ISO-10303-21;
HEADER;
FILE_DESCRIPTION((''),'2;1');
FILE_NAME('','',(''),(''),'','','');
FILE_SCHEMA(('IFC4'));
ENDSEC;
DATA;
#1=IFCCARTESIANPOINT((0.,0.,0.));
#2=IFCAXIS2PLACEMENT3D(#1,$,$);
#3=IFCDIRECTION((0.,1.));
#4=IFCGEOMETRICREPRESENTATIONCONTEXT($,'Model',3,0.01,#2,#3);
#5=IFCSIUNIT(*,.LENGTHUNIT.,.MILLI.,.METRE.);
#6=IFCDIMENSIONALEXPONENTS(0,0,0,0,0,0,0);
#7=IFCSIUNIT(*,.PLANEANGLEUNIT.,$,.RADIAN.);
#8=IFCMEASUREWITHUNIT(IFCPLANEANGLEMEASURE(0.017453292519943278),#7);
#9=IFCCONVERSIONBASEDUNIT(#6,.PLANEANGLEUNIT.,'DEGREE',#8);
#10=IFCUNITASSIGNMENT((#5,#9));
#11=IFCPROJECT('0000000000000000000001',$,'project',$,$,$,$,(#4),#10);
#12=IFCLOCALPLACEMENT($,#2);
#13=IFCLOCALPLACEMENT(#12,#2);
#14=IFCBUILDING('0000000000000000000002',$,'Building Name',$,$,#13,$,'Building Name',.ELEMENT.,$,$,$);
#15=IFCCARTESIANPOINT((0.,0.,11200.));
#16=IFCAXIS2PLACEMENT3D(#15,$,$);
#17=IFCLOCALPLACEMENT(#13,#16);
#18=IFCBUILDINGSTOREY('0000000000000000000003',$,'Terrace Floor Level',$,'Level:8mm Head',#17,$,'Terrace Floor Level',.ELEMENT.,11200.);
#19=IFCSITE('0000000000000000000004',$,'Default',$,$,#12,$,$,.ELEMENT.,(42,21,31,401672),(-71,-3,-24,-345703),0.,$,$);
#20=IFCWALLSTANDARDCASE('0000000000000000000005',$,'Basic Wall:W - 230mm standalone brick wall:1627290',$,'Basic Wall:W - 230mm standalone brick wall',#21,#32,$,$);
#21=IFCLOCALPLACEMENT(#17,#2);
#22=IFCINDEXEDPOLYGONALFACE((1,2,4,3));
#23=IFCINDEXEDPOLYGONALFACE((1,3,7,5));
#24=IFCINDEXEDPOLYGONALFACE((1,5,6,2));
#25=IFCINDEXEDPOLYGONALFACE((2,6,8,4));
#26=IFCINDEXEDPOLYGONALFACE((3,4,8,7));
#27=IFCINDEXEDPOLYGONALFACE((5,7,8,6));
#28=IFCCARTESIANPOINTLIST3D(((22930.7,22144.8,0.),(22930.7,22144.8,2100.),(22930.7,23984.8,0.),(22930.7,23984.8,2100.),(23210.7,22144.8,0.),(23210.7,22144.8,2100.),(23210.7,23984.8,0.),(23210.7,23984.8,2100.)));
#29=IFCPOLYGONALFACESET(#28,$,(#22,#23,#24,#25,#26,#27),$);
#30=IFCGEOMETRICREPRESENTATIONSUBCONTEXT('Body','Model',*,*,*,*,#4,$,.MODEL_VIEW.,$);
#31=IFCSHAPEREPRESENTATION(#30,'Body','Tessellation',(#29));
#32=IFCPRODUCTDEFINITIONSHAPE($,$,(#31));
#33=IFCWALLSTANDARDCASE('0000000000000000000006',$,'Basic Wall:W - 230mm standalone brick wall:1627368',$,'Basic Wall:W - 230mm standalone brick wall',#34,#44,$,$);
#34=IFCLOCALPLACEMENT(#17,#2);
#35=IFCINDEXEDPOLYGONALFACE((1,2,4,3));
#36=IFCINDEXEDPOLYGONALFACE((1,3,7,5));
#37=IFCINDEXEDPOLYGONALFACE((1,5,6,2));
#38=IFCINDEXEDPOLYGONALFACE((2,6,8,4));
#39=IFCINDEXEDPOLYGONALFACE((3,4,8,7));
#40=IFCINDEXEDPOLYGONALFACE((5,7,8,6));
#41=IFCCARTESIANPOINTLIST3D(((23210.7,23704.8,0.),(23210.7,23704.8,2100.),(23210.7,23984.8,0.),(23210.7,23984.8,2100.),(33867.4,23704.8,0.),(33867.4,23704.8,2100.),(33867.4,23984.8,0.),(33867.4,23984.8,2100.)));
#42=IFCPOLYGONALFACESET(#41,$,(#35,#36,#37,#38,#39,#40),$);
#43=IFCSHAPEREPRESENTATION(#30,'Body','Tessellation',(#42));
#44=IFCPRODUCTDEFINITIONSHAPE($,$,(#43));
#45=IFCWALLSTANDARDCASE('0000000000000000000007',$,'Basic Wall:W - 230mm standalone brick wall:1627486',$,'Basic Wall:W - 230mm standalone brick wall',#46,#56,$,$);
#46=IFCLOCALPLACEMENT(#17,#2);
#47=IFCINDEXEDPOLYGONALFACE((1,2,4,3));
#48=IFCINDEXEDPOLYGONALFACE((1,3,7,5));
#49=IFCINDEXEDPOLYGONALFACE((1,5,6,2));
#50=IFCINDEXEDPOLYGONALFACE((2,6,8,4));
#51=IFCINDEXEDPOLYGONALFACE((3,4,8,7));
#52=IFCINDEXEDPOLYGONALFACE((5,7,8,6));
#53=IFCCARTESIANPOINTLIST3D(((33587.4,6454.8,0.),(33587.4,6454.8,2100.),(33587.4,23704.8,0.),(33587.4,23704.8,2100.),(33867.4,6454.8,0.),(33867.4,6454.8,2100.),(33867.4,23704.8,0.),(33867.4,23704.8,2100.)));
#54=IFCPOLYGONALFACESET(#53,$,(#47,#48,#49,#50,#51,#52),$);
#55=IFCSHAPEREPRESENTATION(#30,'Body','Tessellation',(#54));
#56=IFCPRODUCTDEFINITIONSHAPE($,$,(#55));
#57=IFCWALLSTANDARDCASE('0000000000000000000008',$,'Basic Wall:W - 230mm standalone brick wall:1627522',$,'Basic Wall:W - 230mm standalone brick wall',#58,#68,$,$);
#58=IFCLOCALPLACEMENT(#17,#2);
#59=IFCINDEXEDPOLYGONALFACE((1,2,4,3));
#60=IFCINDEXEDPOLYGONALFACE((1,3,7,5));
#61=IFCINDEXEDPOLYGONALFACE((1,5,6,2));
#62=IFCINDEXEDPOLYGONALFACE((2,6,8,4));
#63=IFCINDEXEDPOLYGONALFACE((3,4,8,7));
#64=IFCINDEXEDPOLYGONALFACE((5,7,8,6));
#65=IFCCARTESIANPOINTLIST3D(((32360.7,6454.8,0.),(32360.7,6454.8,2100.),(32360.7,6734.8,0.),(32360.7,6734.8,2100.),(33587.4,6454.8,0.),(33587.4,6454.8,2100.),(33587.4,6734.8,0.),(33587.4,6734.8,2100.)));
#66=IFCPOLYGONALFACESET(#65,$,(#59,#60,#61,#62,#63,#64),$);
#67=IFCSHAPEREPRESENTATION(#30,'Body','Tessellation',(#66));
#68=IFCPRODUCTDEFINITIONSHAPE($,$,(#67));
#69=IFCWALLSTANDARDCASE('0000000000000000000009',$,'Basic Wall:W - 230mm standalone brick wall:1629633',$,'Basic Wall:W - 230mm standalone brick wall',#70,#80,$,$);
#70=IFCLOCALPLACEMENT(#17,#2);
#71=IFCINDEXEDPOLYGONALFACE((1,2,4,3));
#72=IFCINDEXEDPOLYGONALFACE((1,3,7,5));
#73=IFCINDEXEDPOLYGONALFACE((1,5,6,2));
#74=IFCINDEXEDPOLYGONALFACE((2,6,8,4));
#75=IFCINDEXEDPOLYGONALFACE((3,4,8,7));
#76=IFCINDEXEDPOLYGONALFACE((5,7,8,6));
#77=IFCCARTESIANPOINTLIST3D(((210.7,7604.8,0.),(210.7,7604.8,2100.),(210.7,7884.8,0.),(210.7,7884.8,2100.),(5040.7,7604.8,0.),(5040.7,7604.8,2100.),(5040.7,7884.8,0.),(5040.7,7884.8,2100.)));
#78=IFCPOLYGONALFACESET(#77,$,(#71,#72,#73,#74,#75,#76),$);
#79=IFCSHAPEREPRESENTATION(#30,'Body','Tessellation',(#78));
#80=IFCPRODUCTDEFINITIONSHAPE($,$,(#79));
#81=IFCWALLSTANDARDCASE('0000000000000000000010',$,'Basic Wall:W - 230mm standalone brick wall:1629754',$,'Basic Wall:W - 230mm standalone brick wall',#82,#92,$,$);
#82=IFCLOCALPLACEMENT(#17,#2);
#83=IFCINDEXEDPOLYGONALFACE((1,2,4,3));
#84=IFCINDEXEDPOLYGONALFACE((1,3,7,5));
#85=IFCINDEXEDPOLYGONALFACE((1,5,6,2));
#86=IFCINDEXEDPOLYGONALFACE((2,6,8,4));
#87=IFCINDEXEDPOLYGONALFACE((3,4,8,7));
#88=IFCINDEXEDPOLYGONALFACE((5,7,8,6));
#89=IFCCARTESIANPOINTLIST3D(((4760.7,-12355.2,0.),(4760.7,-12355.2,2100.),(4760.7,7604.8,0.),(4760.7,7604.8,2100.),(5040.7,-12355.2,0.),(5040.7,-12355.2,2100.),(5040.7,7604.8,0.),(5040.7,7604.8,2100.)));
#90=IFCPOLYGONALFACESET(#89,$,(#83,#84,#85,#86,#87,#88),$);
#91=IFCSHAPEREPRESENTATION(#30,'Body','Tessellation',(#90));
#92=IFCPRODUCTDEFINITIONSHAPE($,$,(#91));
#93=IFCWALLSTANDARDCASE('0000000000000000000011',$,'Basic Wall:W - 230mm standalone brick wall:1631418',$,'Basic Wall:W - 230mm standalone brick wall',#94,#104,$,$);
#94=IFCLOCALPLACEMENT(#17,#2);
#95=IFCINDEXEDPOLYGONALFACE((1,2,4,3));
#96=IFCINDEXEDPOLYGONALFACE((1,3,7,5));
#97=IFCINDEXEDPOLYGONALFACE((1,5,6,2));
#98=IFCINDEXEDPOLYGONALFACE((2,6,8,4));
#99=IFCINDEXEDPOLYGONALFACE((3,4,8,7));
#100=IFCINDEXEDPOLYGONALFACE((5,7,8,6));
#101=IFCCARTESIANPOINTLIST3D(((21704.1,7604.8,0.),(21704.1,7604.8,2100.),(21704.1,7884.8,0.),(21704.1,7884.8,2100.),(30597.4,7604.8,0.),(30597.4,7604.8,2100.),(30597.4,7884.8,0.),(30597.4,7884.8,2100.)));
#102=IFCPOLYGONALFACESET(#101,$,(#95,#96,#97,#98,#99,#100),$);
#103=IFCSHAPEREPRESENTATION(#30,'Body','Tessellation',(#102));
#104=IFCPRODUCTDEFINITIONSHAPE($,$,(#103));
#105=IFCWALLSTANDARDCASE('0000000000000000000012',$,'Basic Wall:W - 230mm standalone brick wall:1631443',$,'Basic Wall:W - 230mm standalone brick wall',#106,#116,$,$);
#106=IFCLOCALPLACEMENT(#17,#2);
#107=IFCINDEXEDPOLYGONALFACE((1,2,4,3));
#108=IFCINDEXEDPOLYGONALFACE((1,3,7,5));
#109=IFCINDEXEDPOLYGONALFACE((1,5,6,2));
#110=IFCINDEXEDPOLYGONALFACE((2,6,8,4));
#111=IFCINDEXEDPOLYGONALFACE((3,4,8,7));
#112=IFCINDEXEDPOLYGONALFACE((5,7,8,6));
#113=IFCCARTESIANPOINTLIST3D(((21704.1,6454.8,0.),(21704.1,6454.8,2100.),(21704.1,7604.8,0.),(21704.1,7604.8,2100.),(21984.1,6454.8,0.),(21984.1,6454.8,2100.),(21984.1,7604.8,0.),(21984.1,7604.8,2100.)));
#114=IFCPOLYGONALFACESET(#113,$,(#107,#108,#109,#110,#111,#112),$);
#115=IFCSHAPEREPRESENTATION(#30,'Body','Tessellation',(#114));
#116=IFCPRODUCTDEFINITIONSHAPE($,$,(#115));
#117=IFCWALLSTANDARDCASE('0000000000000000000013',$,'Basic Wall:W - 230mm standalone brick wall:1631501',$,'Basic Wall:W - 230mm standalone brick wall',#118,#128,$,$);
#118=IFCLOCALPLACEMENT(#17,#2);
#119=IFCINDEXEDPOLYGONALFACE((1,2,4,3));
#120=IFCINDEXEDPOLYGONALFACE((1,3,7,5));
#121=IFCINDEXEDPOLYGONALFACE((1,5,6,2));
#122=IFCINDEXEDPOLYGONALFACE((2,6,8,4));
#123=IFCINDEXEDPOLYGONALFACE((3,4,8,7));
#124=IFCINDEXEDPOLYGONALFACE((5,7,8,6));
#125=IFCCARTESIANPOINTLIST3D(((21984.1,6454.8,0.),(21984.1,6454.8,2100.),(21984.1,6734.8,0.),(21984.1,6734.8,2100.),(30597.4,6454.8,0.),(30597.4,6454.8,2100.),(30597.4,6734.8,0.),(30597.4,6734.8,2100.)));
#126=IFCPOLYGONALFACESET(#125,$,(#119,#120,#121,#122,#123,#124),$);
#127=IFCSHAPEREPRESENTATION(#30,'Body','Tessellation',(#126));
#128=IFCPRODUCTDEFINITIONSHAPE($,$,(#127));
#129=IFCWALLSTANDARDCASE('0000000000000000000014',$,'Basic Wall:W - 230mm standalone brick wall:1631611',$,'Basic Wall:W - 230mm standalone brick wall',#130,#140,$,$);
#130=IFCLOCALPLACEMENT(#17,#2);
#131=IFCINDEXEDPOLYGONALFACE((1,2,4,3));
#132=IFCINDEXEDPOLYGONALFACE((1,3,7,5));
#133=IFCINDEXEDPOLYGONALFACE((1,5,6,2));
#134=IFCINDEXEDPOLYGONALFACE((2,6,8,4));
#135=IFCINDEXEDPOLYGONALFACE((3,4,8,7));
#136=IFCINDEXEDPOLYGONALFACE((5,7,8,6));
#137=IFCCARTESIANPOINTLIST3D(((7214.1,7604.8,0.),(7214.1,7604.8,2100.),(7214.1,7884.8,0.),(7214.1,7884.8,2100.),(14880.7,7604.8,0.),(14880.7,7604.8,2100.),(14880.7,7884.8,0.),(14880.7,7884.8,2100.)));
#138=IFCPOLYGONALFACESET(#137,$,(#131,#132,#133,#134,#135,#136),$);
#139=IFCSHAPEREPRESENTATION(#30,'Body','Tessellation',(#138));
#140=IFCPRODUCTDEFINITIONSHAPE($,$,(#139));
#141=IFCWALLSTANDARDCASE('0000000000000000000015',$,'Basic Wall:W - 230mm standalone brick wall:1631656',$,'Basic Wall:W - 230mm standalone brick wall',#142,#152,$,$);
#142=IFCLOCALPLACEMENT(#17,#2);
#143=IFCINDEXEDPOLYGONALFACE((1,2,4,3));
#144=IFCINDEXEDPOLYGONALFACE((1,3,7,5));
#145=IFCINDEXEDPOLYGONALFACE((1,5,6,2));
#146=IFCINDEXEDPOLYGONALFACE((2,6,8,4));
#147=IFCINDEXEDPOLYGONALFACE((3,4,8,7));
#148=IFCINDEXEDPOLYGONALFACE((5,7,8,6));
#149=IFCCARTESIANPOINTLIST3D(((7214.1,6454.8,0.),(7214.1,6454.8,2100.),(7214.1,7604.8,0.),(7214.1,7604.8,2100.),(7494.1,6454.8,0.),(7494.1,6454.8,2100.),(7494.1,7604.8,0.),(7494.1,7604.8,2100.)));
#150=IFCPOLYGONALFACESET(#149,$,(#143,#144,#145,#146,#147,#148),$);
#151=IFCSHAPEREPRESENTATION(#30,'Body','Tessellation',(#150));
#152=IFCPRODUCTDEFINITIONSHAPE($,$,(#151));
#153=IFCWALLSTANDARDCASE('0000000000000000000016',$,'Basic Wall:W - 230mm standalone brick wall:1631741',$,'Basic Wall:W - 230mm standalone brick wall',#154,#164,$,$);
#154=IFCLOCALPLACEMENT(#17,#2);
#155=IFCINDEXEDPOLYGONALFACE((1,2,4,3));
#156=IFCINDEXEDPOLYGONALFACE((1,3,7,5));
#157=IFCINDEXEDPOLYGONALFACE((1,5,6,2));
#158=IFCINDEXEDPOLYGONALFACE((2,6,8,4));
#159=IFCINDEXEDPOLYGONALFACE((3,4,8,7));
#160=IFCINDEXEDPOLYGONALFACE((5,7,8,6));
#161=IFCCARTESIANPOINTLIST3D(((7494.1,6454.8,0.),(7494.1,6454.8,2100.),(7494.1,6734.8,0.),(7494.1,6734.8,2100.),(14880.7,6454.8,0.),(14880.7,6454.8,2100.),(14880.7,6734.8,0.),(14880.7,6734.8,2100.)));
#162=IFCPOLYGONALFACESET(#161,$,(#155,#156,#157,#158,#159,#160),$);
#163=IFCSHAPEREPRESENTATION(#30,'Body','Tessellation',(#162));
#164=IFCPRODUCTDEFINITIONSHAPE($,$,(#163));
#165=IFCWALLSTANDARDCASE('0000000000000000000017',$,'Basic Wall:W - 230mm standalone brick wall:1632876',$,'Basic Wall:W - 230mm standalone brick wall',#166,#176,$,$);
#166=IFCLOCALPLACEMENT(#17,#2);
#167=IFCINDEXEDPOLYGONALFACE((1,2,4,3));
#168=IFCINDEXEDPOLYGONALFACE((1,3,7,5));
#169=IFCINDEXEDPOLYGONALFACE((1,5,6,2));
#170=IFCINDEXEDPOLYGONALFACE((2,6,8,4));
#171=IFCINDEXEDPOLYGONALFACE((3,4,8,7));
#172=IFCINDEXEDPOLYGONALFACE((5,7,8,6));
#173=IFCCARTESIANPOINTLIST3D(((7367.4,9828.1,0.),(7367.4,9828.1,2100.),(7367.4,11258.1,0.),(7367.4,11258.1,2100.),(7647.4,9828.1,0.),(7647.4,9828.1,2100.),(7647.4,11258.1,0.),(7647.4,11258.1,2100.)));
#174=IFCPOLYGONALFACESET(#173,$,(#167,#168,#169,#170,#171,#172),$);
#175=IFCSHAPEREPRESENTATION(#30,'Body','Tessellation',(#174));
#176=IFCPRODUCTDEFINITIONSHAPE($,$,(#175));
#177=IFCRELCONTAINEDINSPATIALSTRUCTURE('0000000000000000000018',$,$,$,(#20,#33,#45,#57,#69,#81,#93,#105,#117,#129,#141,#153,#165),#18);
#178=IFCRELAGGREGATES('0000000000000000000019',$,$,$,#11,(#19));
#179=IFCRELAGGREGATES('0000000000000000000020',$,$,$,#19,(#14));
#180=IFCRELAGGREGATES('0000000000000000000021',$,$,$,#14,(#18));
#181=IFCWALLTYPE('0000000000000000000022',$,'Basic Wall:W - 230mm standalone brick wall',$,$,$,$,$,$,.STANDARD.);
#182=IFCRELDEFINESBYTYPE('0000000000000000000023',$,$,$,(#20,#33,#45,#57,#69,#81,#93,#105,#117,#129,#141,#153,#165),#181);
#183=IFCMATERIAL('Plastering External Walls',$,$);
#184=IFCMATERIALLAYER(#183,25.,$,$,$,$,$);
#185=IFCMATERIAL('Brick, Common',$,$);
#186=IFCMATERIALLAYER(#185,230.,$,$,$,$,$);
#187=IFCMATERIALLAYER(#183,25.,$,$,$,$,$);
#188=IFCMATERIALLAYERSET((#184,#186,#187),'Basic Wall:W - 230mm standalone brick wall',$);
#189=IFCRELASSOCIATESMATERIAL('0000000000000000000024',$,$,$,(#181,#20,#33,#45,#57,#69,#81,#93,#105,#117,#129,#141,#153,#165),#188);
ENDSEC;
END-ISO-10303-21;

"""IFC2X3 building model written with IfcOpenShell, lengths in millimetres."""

from ifc_helpers import new_model, entity, si_unit, converted_unit, direction, frame, frame_2d, origin, place, context, subcontext, project, spatial, rectangle, extrude, material, layer, layer_set, layer_usage, type_object, element, save


model = new_model("IFC2X3")

# Units and contexts
model_context = context("Model", 3, precision=0.01, world=origin(), true_north=direction((0.0, 1.0)))
body_context = subcontext(model_context, "Body", "Model", "MODEL_VIEW")
ifc_project = project(units=[si_unit("LENGTHUNIT", "METRE", prefix="MILLI"), converted_unit("PLANEANGLEUNIT", "DEGREE", entity("IfcPlaneAngleMeasure", 0.017453292519943278), si_unit("PLANEANGLEUNIT", "RADIAN"), dimensions=[0, 0, 0, 0, 0, 0, 0])], contexts=[model_context])

# Site, building, storey
site_placement = place(None, origin())
site = spatial("IfcSite", under=ifc_project, at=site_placement, Name="Default", CompositionType="ELEMENT", RefLatitude=(42, 21, 31, 401672), RefLongitude=(-71, -3, -24, -345703), RefElevation=0.0)
building_placement = place(site_placement, origin())
building = spatial("IfcBuilding", under=site, at=building_placement, Name="Building Name", LongName="Building Name", CompositionType="ELEMENT")
storey_placement = place(building_placement, frame((0.0, 0.0, 11200.0)))
storey = spatial("IfcBuildingStorey", under=building, at=storey_placement, Name="Terrace Floor Level", ObjectType="Level:8mm Head", LongName="Terrace Floor Level", CompositionType="ELEMENT", Elevation=11200.0)

# Walls
ifc_material_1 = material(Name="Plastering External Walls")
ifc_layer_1 = layer(ifc_material_1, 25.0)
ifc_material_2 = material(Name="Brick, Common")
ifc_layer_2 = layer(ifc_material_2, 230.0)
ifc_layer_3 = layer(ifc_material_1, 25.0)
ifc_layer_set = layer_set([ifc_layer_1, ifc_layer_2, ifc_layer_3], Name="Basic Wall:W - 230mm standalone brick wall")
ifc_layer_usage_1 = layer_usage(ifc_layer_set, "AXIS2", "NEGATIVE", 140.0)
wall_type = type_object("IfcWallType", Name="Basic Wall:W - 230mm standalone brick wall", PredefinedType="STANDARD", material=ifc_layer_set)
wall_1_placement = place(storey_placement, frame((23070.7, 22144.8, 0.0), z_axis=(0.0, 0.0, 1.0), x_axis=(0.0, 1.0, 0.0)))
element("IfcWallStandardCase", 1, at=wall_1_placement, inside=storey, type_object=wall_type, material=ifc_layer_usage_1, Name="Basic Wall:W - 230mm standalone brick wall:1627290", ObjectType="Basic Wall:W - 230mm standalone brick wall", context=body_context, shape_type="SweptSolid", body=[
    extrude(rectangle(XDim=1840.0, YDim=280.0, at=frame_2d((920.0, 0.0), x_axis=(-1.0, 0.0))), origin(), (0.0, 0.0, 1.0), 2100.0),
])
ifc_layer_usage_2 = layer_usage(ifc_layer_set, "AXIS2", "NEGATIVE", 140.0)
wall_2_placement = place(storey_placement, frame((23210.7, 23844.8, 0.0)))
element("IfcWallStandardCase", 2, at=wall_2_placement, inside=storey, type_object=wall_type, material=ifc_layer_usage_2, Name="Basic Wall:W - 230mm standalone brick wall:1627368", ObjectType="Basic Wall:W - 230mm standalone brick wall", context=body_context, shape_type="SweptSolid", body=[
    extrude(rectangle(XDim=10656.7, YDim=280.0, at=frame_2d((5328.3, 0.0), x_axis=(-1.0, 0.0))), origin(), (0.0, 0.0, 1.0), 2100.0),
])
ifc_layer_usage_3 = layer_usage(ifc_layer_set, "AXIS2", "NEGATIVE", 140.0)
wall_3_placement = place(storey_placement, frame((33727.4, 23704.8, 0.0), z_axis=(0.0, 0.0, 1.0), x_axis=(0.0, -1.0, 0.0)))
element("IfcWallStandardCase", 3, at=wall_3_placement, inside=storey, type_object=wall_type, material=ifc_layer_usage_3, Name="Basic Wall:W - 230mm standalone brick wall:1627486", ObjectType="Basic Wall:W - 230mm standalone brick wall", context=body_context, shape_type="SweptSolid", body=[
    extrude(rectangle(XDim=17250.0, YDim=280.0, at=frame_2d((8625.0, 0.0), x_axis=(-1.0, 0.0))), origin(), (0.0, 0.0, 1.0), 2100.0),
])
ifc_layer_usage_4 = layer_usage(ifc_layer_set, "AXIS2", "NEGATIVE", 140.0)
wall_4_placement = place(storey_placement, frame((33587.4, 6594.8, 0.0), z_axis=(0.0, 0.0, 1.0), x_axis=(-1.0, 0.0, 0.0)))
element("IfcWallStandardCase", 4, at=wall_4_placement, inside=storey, type_object=wall_type, material=ifc_layer_usage_4, Name="Basic Wall:W - 230mm standalone brick wall:1627522", ObjectType="Basic Wall:W - 230mm standalone brick wall", context=body_context, shape_type="SweptSolid", body=[
    extrude(rectangle(XDim=1226.7, YDim=280.0, at=frame_2d((613.3, 0.0), x_axis=(-1.0, 0.0))), origin(), (0.0, 0.0, 1.0), 2100.0),
])
ifc_layer_usage_5 = layer_usage(ifc_layer_set, "AXIS2", "NEGATIVE", 140.0)
wall_5_placement = place(storey_placement, frame((210.7, 7744.8, 0.0)))
element("IfcWallStandardCase", 5, at=wall_5_placement, inside=storey, type_object=wall_type, material=ifc_layer_usage_5, Name="Basic Wall:W - 230mm standalone brick wall:1629633", ObjectType="Basic Wall:W - 230mm standalone brick wall", context=body_context, shape_type="SweptSolid", body=[
    extrude(rectangle(XDim=4830.0, YDim=280.0, at=frame_2d((2415.0, 0.0), x_axis=(-1.0, 0.0))), origin(), (0.0, 0.0, 1.0), 2100.0),
])
ifc_layer_usage_6 = layer_usage(ifc_layer_set, "AXIS2", "NEGATIVE", 140.0)
wall_6_placement = place(storey_placement, frame((4900.7, 7604.8, 0.0), z_axis=(0.0, 0.0, 1.0), x_axis=(0.0, -1.0, 0.0)))
element("IfcWallStandardCase", 6, at=wall_6_placement, inside=storey, type_object=wall_type, material=ifc_layer_usage_6, Name="Basic Wall:W - 230mm standalone brick wall:1629754", ObjectType="Basic Wall:W - 230mm standalone brick wall", context=body_context, shape_type="SweptSolid", body=[
    extrude(rectangle(XDim=19960.0, YDim=280.0, at=frame_2d((9980.0, 0.0), x_axis=(-1.0, 0.0))), origin(), (0.0, 0.0, 1.0), 2100.0),
])
ifc_layer_usage_7 = layer_usage(ifc_layer_set, "AXIS2", "NEGATIVE", 140.0)
wall_7_placement = place(storey_placement, frame((30597.4, 7744.8, 0.0), z_axis=(0.0, 0.0, 1.0), x_axis=(-1.0, 0.0, 0.0)))
element("IfcWallStandardCase", 7, at=wall_7_placement, inside=storey, type_object=wall_type, material=ifc_layer_usage_7, Name="Basic Wall:W - 230mm standalone brick wall:1631418", ObjectType="Basic Wall:W - 230mm standalone brick wall", context=body_context, shape_type="SweptSolid", body=[
    extrude(rectangle(XDim=8893.3, YDim=280.0, at=frame_2d((4446.7, 0.0), x_axis=(-1.0, 0.0))), origin(), (0.0, 0.0, 1.0), 2100.0),
])
ifc_layer_usage_8 = layer_usage(ifc_layer_set, "AXIS2", "NEGATIVE", 140.0)
wall_8_placement = place(storey_placement, frame((21844.1, 7604.8, 0.0), z_axis=(0.0, 0.0, 1.0), x_axis=(0.0, -1.0, 0.0)))
element("IfcWallStandardCase", 8, at=wall_8_placement, inside=storey, type_object=wall_type, material=ifc_layer_usage_8, Name="Basic Wall:W - 230mm standalone brick wall:1631443", ObjectType="Basic Wall:W - 230mm standalone brick wall", context=body_context, shape_type="SweptSolid", body=[
    extrude(rectangle(XDim=1150.0, YDim=280.0, at=frame_2d((575.0, 0.0), x_axis=(-1.0, 0.0))), origin(), (0.0, 0.0, 1.0), 2100.0),
])
ifc_layer_usage_9 = layer_usage(ifc_layer_set, "AXIS2", "NEGATIVE", 140.0)
wall_9_placement = place(storey_placement, frame((21984.1, 6594.8, 0.0)))
element("IfcWallStandardCase", 9, at=wall_9_placement, inside=storey, type_object=wall_type, material=ifc_layer_usage_9, Name="Basic Wall:W - 230mm standalone brick wall:1631501", ObjectType="Basic Wall:W - 230mm standalone brick wall", context=body_context, shape_type="SweptSolid", body=[
    extrude(rectangle(XDim=8613.3, YDim=280.0, at=frame_2d((4306.7, 0.0), x_axis=(-1.0, 0.0))), origin(), (0.0, 0.0, 1.0), 2100.0),
])
ifc_layer_usage_10 = layer_usage(ifc_layer_set, "AXIS2", "NEGATIVE", 140.0)
wall_10_placement = place(storey_placement, frame((14880.7, 7744.8, 0.0), z_axis=(0.0, 0.0, 1.0), x_axis=(-1.0, 0.0, 0.0)))
element("IfcWallStandardCase", 10, at=wall_10_placement, inside=storey, type_object=wall_type, material=ifc_layer_usage_10, Name="Basic Wall:W - 230mm standalone brick wall:1631611", ObjectType="Basic Wall:W - 230mm standalone brick wall", context=body_context, shape_type="SweptSolid", body=[
    extrude(rectangle(XDim=7666.7, YDim=280.0, at=frame_2d((3833.3, 0.0), x_axis=(-1.0, 0.0))), origin(), (0.0, 0.0, 1.0), 2100.0),
])
ifc_layer_usage_11 = layer_usage(ifc_layer_set, "AXIS2", "NEGATIVE", 140.0)
wall_11_placement = place(storey_placement, frame((7354.1, 7604.8, 0.0), z_axis=(0.0, 0.0, 1.0), x_axis=(0.0, -1.0, 0.0)))
element("IfcWallStandardCase", 11, at=wall_11_placement, inside=storey, type_object=wall_type, material=ifc_layer_usage_11, Name="Basic Wall:W - 230mm standalone brick wall:1631656", ObjectType="Basic Wall:W - 230mm standalone brick wall", context=body_context, shape_type="SweptSolid", body=[
    extrude(rectangle(XDim=1150.0, YDim=280.0, at=frame_2d((575.0, 0.0), x_axis=(-1.0, 0.0))), origin(), (0.0, 0.0, 1.0), 2100.0),
])
ifc_layer_usage_12 = layer_usage(ifc_layer_set, "AXIS2", "NEGATIVE", 140.0)
wall_12_placement = place(storey_placement, frame((7494.1, 6594.8, 0.0)))
element("IfcWallStandardCase", 12, at=wall_12_placement, inside=storey, type_object=wall_type, material=ifc_layer_usage_12, Name="Basic Wall:W - 230mm standalone brick wall:1631741", ObjectType="Basic Wall:W - 230mm standalone brick wall", context=body_context, shape_type="SweptSolid", body=[
    extrude(rectangle(XDim=7386.7, YDim=280.0, at=frame_2d((3693.3, 0.0), x_axis=(-1.0, 0.0))), origin(), (0.0, 0.0, 1.0), 2100.0),
])
ifc_layer_usage_13 = layer_usage(ifc_layer_set, "AXIS2", "NEGATIVE", 140.0)
wall_13_placement = place(storey_placement, frame((7507.4, 9828.1, 0.0), z_axis=(0.0, 0.0, 1.0), x_axis=(0.0, 1.0, 0.0)))
element("IfcWallStandardCase", 13, at=wall_13_placement, inside=storey, type_object=wall_type, material=ifc_layer_usage_13, Name="Basic Wall:W - 230mm standalone brick wall:1632876", ObjectType="Basic Wall:W - 230mm standalone brick wall", context=body_context, shape_type="SweptSolid", body=[
    extrude(rectangle(XDim=1430.0, YDim=280.0, at=frame_2d((715.0, 0.0), x_axis=(-1.0, 0.0))), origin(), (0.0, 0.0, 1.0), 2100.0),
])

save(model, "model.ifc")
